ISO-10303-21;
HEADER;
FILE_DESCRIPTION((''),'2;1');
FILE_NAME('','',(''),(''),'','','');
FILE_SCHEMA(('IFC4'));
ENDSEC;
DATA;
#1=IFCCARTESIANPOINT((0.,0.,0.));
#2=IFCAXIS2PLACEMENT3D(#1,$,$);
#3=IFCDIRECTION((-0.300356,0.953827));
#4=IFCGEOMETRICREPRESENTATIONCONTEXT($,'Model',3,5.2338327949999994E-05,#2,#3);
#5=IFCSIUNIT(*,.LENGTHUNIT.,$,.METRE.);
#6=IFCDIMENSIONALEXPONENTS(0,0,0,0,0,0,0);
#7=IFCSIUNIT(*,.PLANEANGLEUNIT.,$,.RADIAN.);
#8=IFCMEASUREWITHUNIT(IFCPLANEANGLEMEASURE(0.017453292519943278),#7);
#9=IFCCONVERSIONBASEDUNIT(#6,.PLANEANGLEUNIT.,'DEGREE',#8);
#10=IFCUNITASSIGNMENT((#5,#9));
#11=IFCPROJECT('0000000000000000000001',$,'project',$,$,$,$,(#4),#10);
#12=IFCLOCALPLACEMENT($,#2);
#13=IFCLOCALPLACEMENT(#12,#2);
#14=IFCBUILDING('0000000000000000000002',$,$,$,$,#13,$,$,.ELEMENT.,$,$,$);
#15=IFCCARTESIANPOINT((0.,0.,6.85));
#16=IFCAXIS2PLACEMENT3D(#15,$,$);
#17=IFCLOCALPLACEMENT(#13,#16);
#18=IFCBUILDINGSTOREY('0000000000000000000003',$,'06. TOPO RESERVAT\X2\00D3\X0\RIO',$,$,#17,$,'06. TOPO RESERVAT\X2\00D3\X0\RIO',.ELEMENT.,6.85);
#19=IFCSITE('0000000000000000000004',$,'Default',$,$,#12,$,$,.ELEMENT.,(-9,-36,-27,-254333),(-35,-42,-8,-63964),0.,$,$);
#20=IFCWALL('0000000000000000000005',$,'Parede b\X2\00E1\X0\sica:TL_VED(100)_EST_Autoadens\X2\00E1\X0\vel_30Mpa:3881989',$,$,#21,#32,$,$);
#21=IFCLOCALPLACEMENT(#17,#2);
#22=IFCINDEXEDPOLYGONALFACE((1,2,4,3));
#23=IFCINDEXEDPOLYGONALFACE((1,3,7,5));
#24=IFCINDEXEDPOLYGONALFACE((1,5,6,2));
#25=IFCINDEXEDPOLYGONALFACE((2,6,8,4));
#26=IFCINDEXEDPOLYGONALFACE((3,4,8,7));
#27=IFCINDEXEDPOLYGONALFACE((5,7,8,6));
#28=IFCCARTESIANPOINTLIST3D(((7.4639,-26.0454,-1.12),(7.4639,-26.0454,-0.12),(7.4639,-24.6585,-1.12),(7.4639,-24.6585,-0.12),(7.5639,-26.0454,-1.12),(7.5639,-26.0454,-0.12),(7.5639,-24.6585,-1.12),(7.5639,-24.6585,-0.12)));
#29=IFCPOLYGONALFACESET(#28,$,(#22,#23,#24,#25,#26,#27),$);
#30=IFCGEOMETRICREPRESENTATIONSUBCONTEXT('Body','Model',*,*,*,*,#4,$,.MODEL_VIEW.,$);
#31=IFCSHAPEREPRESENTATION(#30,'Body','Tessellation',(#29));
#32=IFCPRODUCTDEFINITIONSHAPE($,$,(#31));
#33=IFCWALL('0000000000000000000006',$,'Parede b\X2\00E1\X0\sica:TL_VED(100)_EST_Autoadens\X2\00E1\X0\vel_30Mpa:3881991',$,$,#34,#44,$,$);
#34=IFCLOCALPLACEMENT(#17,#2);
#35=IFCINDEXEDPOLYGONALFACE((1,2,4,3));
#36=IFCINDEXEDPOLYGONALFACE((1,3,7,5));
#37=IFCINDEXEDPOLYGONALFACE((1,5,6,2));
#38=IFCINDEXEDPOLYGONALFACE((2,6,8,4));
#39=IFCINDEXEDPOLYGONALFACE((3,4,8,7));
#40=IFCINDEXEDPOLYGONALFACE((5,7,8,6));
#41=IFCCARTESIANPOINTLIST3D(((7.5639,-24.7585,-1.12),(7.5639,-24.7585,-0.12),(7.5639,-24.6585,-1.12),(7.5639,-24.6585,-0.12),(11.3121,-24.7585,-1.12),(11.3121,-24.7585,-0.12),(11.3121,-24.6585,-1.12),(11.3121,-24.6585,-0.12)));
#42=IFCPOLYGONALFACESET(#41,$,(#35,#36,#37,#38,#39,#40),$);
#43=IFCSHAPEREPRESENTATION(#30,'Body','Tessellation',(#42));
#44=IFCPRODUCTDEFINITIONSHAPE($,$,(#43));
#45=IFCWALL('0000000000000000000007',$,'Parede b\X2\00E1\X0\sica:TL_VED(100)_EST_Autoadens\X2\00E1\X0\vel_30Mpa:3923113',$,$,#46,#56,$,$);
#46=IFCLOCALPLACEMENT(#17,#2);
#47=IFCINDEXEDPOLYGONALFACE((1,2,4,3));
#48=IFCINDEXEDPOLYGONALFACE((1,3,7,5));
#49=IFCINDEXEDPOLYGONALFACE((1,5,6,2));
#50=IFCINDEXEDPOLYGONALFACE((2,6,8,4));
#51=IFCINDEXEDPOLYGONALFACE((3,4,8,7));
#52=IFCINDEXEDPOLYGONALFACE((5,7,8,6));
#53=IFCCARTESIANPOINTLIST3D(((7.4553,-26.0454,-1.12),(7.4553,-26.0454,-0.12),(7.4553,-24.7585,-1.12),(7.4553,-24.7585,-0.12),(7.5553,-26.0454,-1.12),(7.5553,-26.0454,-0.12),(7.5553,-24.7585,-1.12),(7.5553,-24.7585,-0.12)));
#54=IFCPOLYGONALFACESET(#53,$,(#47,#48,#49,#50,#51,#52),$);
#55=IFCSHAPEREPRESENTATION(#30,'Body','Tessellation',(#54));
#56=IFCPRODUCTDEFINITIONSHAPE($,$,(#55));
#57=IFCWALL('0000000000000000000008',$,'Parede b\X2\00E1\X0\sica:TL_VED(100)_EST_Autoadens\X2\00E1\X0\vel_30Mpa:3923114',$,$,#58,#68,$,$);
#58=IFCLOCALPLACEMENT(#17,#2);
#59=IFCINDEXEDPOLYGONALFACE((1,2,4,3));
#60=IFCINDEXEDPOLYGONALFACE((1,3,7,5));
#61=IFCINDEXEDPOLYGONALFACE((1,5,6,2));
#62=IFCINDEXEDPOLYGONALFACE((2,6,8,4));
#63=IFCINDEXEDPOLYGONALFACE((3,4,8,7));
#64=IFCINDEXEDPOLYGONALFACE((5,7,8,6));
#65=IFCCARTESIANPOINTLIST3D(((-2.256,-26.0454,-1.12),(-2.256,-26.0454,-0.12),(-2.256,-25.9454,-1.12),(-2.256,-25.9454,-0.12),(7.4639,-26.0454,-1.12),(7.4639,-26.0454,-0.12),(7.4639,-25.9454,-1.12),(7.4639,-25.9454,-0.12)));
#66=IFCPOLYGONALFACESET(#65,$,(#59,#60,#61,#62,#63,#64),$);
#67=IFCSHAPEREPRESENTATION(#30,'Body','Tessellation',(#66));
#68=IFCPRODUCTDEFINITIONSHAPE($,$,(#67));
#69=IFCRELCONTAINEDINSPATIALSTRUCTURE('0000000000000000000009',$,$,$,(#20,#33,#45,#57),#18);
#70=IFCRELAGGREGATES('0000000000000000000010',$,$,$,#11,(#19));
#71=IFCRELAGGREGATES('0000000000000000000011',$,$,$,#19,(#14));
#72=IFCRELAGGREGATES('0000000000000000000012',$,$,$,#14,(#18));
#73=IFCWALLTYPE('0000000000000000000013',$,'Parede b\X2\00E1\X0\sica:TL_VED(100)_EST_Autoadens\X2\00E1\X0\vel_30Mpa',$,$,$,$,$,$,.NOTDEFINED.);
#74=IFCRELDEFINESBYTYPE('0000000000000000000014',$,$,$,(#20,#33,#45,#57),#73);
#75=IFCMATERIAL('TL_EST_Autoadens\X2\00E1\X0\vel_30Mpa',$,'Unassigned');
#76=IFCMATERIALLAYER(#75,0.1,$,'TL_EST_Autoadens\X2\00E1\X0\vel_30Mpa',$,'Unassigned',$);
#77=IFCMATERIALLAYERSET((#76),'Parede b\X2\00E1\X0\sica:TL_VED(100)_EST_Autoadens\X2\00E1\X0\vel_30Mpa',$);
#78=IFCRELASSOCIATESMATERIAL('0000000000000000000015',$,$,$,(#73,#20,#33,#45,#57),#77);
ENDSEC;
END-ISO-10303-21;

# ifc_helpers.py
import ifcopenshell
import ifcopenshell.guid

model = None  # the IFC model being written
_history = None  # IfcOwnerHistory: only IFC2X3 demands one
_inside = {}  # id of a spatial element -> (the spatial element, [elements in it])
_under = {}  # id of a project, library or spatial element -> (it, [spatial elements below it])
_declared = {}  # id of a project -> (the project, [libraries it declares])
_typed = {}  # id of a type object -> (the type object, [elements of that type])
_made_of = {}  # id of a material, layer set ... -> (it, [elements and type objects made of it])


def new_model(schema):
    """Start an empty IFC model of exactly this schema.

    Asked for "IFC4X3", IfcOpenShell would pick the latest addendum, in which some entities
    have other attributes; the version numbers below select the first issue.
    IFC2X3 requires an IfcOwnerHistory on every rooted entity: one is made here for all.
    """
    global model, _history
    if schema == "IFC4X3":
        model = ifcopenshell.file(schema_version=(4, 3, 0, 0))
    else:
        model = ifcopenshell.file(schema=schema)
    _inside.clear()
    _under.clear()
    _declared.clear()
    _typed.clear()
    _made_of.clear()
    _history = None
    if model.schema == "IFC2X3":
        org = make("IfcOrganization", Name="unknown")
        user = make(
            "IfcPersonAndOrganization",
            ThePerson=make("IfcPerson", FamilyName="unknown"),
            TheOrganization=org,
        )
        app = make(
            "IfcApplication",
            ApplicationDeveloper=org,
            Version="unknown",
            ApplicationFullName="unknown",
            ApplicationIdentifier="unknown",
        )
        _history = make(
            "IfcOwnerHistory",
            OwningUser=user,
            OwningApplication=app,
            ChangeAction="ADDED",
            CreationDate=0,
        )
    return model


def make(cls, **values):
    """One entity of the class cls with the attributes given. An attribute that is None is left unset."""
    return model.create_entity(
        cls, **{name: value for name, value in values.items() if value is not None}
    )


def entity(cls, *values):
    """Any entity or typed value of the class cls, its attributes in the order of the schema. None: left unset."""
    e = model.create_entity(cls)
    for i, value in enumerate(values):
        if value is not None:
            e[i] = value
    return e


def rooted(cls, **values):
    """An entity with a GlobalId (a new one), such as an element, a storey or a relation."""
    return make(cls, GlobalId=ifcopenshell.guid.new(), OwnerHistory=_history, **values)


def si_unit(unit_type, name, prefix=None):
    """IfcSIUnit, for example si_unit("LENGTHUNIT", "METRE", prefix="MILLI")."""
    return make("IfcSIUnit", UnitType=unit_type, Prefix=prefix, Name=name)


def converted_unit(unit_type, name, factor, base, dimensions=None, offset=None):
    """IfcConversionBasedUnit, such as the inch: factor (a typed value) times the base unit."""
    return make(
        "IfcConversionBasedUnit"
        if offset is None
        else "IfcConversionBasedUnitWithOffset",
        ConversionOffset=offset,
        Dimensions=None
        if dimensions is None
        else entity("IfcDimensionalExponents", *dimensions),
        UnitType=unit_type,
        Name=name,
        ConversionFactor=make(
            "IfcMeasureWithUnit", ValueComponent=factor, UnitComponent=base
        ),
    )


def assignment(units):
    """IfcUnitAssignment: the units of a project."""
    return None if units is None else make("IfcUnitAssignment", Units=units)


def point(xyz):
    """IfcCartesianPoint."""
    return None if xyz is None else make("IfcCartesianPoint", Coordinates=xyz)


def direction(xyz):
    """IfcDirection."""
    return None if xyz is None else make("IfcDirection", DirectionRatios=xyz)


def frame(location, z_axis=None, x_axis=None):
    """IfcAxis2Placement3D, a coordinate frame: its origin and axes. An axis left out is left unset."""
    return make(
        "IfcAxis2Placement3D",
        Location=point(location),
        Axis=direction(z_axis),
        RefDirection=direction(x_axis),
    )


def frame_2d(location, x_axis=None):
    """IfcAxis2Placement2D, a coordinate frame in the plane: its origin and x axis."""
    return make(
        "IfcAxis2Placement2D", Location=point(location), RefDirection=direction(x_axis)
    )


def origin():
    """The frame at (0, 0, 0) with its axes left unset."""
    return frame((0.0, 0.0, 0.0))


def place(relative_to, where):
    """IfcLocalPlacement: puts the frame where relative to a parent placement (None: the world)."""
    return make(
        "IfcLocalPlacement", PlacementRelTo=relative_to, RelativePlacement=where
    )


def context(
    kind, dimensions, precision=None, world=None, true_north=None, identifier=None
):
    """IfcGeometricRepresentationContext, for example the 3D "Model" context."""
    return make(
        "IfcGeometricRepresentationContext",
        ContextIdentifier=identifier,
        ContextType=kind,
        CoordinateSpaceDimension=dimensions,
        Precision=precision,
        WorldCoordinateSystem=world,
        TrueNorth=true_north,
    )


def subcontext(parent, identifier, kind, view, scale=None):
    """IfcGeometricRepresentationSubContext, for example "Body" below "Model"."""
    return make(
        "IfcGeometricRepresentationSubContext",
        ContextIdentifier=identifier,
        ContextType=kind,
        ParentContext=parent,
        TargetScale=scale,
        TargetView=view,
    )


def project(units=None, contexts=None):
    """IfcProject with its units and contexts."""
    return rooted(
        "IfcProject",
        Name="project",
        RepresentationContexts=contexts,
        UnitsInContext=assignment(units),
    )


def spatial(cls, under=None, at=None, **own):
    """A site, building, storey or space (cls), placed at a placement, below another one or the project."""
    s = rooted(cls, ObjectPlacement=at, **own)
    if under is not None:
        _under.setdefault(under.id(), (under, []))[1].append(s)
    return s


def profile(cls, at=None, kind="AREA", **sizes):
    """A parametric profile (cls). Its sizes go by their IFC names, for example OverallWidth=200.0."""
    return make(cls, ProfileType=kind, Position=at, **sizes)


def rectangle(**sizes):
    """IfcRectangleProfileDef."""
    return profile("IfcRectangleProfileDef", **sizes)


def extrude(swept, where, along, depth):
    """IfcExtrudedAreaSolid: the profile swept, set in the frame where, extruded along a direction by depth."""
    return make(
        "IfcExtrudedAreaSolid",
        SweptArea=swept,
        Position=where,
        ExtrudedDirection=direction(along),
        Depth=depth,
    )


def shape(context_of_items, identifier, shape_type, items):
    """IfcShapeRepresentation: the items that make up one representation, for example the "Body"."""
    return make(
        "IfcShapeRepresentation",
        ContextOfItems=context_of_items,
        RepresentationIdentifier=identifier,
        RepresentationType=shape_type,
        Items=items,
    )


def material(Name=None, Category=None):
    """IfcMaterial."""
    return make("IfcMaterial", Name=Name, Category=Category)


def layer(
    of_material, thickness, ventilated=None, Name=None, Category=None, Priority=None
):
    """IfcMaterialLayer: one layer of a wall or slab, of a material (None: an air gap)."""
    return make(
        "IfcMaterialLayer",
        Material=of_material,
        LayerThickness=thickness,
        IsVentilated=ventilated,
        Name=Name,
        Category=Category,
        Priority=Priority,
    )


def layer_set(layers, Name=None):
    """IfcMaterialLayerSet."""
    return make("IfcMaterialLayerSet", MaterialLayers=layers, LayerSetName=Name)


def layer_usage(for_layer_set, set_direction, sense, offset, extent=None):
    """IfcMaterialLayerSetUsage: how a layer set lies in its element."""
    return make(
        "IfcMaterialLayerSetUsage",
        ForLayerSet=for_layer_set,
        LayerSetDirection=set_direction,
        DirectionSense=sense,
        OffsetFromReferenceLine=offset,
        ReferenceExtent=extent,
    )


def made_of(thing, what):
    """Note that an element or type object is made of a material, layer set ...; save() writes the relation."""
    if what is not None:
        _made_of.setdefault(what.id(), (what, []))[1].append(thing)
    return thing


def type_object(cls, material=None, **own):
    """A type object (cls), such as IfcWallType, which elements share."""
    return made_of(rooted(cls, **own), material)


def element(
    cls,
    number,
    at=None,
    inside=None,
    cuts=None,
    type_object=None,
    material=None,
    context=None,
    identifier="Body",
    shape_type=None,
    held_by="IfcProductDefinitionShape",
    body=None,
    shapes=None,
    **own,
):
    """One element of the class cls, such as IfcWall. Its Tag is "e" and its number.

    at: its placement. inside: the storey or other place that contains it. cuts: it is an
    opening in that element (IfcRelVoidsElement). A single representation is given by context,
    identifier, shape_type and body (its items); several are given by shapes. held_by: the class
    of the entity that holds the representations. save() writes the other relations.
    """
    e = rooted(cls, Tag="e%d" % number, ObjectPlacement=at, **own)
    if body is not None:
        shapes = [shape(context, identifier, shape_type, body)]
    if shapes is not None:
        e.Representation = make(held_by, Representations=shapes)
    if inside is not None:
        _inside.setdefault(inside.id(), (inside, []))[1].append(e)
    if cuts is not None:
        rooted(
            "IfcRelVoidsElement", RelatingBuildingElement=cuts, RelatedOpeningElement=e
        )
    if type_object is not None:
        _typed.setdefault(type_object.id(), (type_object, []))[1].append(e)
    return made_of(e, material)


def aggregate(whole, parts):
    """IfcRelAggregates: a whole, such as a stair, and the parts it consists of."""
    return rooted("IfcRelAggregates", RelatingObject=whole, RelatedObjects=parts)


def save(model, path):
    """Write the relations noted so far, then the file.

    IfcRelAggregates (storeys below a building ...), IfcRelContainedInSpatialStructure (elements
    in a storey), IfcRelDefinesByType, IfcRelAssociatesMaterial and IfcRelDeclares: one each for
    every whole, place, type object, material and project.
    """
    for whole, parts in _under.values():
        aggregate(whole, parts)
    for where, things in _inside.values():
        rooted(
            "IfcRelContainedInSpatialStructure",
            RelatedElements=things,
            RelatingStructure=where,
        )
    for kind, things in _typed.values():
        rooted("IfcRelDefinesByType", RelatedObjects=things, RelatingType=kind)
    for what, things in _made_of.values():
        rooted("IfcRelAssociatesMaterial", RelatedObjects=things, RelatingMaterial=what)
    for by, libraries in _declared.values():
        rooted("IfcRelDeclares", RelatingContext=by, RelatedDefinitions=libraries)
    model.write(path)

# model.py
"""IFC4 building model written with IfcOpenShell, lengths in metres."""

from ifc_helpers import new_model, entity, si_unit, converted_unit, direction, frame, frame_2d, origin, place, context, subcontext, project, spatial, rectangle, extrude, material, layer, layer_set, layer_usage, type_object, element, save


model = new_model("IFC4")

# Units and contexts
model_context = context("Model", 3, precision=5.2338327949999994e-05, world=origin(), true_north=direction((-0.300356, 0.953827)))
body_context = subcontext(model_context, "Body", "Model", "MODEL_VIEW")
ifc_project = project(units=[si_unit("LENGTHUNIT", "METRE"), converted_unit("PLANEANGLEUNIT", "DEGREE", entity("IfcPlaneAngleMeasure", 0.017453292519943278), si_unit("PLANEANGLEUNIT", "RADIAN"), dimensions=[0, 0, 0, 0, 0, 0, 0])], contexts=[model_context])

# Site, building, storey
site_placement = place(None, origin())
site = spatial("IfcSite", under=ifc_project, at=site_placement, Name="Default", CompositionType="ELEMENT", RefLatitude=(-9, -36, -27, -254333), RefLongitude=(-35, -42, -8, -63964), RefElevation=0.0)
building_placement = place(site_placement, origin())
building = spatial("IfcBuilding", under=site, at=building_placement, CompositionType="ELEMENT")
storey_placement = place(building_placement, frame((0.0, 0.0, 6.85)))
storey = spatial("IfcBuildingStorey", under=building, at=storey_placement, Name="06. TOPO RESERVATÓRIO", LongName="06. TOPO RESERVATÓRIO", CompositionType="ELEMENT", Elevation=6.85)

# Walls
ifc_material_1 = material(Name="TL_EST_Autoadensável_30Mpa", Category="Unassigned")
ifc_layer = layer(ifc_material_1, 0.1, Name="TL_EST_Autoadensável_30Mpa", Category="Unassigned")
ifc_layer_set = layer_set([ifc_layer], Name="Parede básica:TL_VED(100)_EST_Autoadensável_30Mpa")
ifc_layer_usage_1 = layer_usage(ifc_layer_set, "AXIS2", "POSITIVE", -0.05)
wall_type = type_object("IfcWallType", Name="Parede básica:TL_VED(100)_EST_Autoadensável_30Mpa", PredefinedType="NOTDEFINED", material=ifc_layer_set)
wall_1_placement = place(storey_placement, frame((7.5139, -24.6585, -1.12), z_axis=(0.0, 0.0, 1.0), x_axis=(0.0, -1.0, 0.0)))
element("IfcWall", 1, at=wall_1_placement, inside=storey, type_object=wall_type, material=ifc_layer_usage_1, Name="Parede básica:TL_VED(100)_EST_Autoadensável_30Mpa:3881989", context=body_context, shape_type="SweptSolid", body=[
    extrude(rectangle(XDim=1.3869, YDim=0.1, at=frame_2d((0.6934, 0.0), x_axis=(-1.0, 0.0))), origin(), (0.0, 0.0, 1.0), 1.0),
])
ifc_layer_usage_2 = layer_usage(ifc_layer_set, "AXIS2", "POSITIVE", -0.05)
wall_2_placement = place(storey_placement, frame((7.5639, -24.7085, -1.12)))
element("IfcWall", 2, at=wall_2_placement, inside=storey, type_object=wall_type, material=ifc_layer_usage_2, Name="Parede básica:TL_VED(100)_EST_Autoadensável_30Mpa:3881991", context=body_context, shape_type="SweptSolid", body=[
    extrude(rectangle(XDim=3.7482, YDim=0.1, at=frame_2d((1.8741, 0.0), x_axis=(-1.0, 0.0))), origin(), (0.0, 0.0, 1.0), 1.0),
])
ifc_layer_usage_3 = layer_usage(ifc_layer_set, "AXIS2", "POSITIVE", -0.05)
wall_3_placement = place(storey_placement, frame((7.5053, -24.7585, -1.12), z_axis=(0.0, 0.0, 1.0), x_axis=(0.0, -1.0, 0.0)))
element("IfcWall", 3, at=wall_3_placement, inside=storey, type_object=wall_type, material=ifc_layer_usage_3, Name="Parede básica:TL_VED(100)_EST_Autoadensável_30Mpa:3923113", context=body_context, shape_type="SweptSolid", body=[
    extrude(rectangle(XDim=1.2869, YDim=0.1, at=frame_2d((0.6434, 0.0), x_axis=(-1.0, 0.0))), origin(), (0.0, 0.0, 1.0), 1.0),
])
ifc_layer_usage_4 = layer_usage(ifc_layer_set, "AXIS2", "POSITIVE", -0.05)
wall_4_placement = place(storey_placement, frame((7.4639, -25.9954, -1.12), z_axis=(0.0, 0.0, 1.0), x_axis=(-1.0, 0.0, 0.0)))
element("IfcWall", 4, at=wall_4_placement, inside=storey, type_object=wall_type, material=ifc_layer_usage_4, Name="Parede básica:TL_VED(100)_EST_Autoadensável_30Mpa:3923114", context=body_context, shape_type="SweptSolid", body=[
    extrude(rectangle(XDim=9.7199, YDim=0.1, at=frame_2d((4.86, 0.0), x_axis=(-1.0, 0.0))), origin(), (0.0, 0.0, 1.0), 1.0),
])

save(model, "model.ifc")
